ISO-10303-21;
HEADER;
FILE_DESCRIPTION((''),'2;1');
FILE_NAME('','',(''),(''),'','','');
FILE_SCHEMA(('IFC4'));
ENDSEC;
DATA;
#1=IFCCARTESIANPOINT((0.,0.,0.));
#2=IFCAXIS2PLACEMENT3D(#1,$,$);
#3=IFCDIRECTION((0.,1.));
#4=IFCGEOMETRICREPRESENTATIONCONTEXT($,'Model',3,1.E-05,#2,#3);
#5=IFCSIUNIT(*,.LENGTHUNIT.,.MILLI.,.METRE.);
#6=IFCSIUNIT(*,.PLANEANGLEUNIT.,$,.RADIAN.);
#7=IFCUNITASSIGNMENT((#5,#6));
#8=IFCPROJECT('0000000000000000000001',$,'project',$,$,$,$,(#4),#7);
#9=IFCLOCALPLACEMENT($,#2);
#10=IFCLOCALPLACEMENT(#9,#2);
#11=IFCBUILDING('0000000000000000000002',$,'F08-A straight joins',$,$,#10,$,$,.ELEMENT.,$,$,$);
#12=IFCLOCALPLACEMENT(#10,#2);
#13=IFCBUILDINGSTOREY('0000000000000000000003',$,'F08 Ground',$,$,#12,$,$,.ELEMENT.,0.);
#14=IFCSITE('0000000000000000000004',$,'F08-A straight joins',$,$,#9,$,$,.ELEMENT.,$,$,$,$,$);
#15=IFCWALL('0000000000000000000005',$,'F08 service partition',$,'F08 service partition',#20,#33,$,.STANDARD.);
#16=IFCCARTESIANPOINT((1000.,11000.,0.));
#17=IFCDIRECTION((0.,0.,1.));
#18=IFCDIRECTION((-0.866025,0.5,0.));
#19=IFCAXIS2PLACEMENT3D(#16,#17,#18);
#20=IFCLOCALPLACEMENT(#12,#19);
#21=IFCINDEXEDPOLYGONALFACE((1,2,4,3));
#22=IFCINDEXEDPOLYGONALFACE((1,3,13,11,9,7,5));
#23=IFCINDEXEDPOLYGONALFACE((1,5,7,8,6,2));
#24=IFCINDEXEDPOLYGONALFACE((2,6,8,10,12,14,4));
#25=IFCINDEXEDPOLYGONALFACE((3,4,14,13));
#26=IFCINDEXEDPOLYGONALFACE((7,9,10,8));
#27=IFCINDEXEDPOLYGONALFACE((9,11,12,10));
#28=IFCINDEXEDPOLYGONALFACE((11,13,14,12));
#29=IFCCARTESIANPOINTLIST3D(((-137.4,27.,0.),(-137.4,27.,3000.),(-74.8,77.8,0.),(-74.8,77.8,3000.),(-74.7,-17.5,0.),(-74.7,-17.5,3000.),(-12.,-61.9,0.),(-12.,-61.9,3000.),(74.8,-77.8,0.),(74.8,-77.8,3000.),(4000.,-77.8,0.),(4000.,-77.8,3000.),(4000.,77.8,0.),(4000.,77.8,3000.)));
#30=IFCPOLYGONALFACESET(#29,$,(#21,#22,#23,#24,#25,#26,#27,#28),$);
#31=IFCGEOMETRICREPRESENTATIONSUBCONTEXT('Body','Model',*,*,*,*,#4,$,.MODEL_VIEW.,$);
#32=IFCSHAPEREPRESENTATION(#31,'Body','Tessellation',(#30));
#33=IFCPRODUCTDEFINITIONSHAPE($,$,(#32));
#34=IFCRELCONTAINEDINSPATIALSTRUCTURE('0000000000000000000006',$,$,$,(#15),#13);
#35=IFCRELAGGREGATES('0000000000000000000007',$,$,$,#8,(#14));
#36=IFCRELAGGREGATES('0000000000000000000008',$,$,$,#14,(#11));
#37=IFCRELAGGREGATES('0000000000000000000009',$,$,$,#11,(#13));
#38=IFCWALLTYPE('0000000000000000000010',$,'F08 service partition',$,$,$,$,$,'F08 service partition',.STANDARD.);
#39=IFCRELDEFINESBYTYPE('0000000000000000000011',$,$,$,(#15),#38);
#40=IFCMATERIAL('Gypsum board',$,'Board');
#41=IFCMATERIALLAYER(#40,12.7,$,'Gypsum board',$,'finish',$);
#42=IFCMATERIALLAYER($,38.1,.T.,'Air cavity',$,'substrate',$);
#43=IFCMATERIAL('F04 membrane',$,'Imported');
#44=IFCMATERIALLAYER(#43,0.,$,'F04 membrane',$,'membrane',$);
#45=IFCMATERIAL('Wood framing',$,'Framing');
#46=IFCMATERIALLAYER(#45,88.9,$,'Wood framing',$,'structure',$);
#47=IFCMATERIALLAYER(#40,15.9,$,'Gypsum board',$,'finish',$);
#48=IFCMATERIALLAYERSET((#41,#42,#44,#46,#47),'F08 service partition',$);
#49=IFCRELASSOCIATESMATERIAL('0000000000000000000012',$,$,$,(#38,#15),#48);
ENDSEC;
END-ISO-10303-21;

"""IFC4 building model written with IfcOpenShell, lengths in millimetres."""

from ifc_helpers import new_model, si_unit, direction, frame, origin, place, context, subcontext, project, spatial, polyline, outline, extrude, material, layer, layer_set, layer_usage, type_object, element, save


model = new_model("IFC4")

# Units and contexts
model_context = context("Model", 3, precision=1e-05, world=origin(), true_north=direction((0.0, 1.0)))
body_context = subcontext(model_context, "Body", "Model", "MODEL_VIEW")
ifc_project = project(units=[si_unit("LENGTHUNIT", "METRE", prefix="MILLI"), si_unit("PLANEANGLEUNIT", "RADIAN")], contexts=[model_context])

# Site, building, storey
site_placement = place(None, origin())
site = spatial("IfcSite", under=ifc_project, at=site_placement, Name="F08-A straight joins", CompositionType="ELEMENT")
building_placement = place(site_placement, origin())
building = spatial("IfcBuilding", under=site, at=building_placement, Name="F08-A straight joins", CompositionType="ELEMENT")
storey_placement = place(building_placement, origin())
storey = spatial("IfcBuildingStorey", under=building, at=storey_placement, Name="F08 Ground", CompositionType="ELEMENT", Elevation=0.0)

# Shared definitions
ifc_material_1 = material(Name="F04 membrane", Category="Imported")
ifc_material_2 = material(Name="Wood framing", Category="Framing")
ifc_material_3 = material(Name="Gypsum board", Category="Board")

# Wall
ifc_layer_1 = layer(ifc_material_3, 12.7, Name="Gypsum board", Category="finish")
ifc_layer_2 = layer(None, 38.1, ventilated=True, Name="Air cavity", Category="substrate")
ifc_layer_3 = layer(ifc_material_1, 0.0, Name="F04 membrane", Category="membrane")
ifc_layer_4 = layer(ifc_material_2, 88.9, Name="Wood framing", Category="structure")
ifc_layer_5 = layer(ifc_material_3, 15.9, Name="Gypsum board", Category="finish")
ifc_layer_set_1 = layer_set([ifc_layer_1, ifc_layer_2, ifc_layer_3, ifc_layer_4, ifc_layer_5], Name="F08 service partition")
wall_type_1 = type_object("IfcWallType", Name="F08 service partition", ElementType="F08 service partition", PredefinedType="STANDARD", material=ifc_layer_set_1)
ifc_layer_usage_1 = layer_usage(ifc_layer_set_1, "AXIS2", "NEGATIVE", 77.8)
wall_1_placement = place(storey_placement, frame((1000.0, 11000.0, 0.0), z_axis=(0.0, 0.0, 1.0), x_axis=(-0.866025, 0.5, 0.0)))
element("IfcWall", 1, at=wall_1_placement, inside=storey, type_object=wall_type_1, material=ifc_layer_usage_1, Name="F08 service partition", ObjectType="F08 service partition", PredefinedType="STANDARD", context=body_context, shape_type="SweptSolid", body=[
    extrude(outline(polyline([(74.8, -77.8), (4000.0, -77.8), (4000.0, 77.8), (-74.8, 77.8), (-137.4, 27.0), (-74.7, -17.5), (-12.0, -61.9), (74.8, -77.8)])), origin(), (0.0, 0.0, 1.0), 3000.0),
])

save(model, "model.ifc")
